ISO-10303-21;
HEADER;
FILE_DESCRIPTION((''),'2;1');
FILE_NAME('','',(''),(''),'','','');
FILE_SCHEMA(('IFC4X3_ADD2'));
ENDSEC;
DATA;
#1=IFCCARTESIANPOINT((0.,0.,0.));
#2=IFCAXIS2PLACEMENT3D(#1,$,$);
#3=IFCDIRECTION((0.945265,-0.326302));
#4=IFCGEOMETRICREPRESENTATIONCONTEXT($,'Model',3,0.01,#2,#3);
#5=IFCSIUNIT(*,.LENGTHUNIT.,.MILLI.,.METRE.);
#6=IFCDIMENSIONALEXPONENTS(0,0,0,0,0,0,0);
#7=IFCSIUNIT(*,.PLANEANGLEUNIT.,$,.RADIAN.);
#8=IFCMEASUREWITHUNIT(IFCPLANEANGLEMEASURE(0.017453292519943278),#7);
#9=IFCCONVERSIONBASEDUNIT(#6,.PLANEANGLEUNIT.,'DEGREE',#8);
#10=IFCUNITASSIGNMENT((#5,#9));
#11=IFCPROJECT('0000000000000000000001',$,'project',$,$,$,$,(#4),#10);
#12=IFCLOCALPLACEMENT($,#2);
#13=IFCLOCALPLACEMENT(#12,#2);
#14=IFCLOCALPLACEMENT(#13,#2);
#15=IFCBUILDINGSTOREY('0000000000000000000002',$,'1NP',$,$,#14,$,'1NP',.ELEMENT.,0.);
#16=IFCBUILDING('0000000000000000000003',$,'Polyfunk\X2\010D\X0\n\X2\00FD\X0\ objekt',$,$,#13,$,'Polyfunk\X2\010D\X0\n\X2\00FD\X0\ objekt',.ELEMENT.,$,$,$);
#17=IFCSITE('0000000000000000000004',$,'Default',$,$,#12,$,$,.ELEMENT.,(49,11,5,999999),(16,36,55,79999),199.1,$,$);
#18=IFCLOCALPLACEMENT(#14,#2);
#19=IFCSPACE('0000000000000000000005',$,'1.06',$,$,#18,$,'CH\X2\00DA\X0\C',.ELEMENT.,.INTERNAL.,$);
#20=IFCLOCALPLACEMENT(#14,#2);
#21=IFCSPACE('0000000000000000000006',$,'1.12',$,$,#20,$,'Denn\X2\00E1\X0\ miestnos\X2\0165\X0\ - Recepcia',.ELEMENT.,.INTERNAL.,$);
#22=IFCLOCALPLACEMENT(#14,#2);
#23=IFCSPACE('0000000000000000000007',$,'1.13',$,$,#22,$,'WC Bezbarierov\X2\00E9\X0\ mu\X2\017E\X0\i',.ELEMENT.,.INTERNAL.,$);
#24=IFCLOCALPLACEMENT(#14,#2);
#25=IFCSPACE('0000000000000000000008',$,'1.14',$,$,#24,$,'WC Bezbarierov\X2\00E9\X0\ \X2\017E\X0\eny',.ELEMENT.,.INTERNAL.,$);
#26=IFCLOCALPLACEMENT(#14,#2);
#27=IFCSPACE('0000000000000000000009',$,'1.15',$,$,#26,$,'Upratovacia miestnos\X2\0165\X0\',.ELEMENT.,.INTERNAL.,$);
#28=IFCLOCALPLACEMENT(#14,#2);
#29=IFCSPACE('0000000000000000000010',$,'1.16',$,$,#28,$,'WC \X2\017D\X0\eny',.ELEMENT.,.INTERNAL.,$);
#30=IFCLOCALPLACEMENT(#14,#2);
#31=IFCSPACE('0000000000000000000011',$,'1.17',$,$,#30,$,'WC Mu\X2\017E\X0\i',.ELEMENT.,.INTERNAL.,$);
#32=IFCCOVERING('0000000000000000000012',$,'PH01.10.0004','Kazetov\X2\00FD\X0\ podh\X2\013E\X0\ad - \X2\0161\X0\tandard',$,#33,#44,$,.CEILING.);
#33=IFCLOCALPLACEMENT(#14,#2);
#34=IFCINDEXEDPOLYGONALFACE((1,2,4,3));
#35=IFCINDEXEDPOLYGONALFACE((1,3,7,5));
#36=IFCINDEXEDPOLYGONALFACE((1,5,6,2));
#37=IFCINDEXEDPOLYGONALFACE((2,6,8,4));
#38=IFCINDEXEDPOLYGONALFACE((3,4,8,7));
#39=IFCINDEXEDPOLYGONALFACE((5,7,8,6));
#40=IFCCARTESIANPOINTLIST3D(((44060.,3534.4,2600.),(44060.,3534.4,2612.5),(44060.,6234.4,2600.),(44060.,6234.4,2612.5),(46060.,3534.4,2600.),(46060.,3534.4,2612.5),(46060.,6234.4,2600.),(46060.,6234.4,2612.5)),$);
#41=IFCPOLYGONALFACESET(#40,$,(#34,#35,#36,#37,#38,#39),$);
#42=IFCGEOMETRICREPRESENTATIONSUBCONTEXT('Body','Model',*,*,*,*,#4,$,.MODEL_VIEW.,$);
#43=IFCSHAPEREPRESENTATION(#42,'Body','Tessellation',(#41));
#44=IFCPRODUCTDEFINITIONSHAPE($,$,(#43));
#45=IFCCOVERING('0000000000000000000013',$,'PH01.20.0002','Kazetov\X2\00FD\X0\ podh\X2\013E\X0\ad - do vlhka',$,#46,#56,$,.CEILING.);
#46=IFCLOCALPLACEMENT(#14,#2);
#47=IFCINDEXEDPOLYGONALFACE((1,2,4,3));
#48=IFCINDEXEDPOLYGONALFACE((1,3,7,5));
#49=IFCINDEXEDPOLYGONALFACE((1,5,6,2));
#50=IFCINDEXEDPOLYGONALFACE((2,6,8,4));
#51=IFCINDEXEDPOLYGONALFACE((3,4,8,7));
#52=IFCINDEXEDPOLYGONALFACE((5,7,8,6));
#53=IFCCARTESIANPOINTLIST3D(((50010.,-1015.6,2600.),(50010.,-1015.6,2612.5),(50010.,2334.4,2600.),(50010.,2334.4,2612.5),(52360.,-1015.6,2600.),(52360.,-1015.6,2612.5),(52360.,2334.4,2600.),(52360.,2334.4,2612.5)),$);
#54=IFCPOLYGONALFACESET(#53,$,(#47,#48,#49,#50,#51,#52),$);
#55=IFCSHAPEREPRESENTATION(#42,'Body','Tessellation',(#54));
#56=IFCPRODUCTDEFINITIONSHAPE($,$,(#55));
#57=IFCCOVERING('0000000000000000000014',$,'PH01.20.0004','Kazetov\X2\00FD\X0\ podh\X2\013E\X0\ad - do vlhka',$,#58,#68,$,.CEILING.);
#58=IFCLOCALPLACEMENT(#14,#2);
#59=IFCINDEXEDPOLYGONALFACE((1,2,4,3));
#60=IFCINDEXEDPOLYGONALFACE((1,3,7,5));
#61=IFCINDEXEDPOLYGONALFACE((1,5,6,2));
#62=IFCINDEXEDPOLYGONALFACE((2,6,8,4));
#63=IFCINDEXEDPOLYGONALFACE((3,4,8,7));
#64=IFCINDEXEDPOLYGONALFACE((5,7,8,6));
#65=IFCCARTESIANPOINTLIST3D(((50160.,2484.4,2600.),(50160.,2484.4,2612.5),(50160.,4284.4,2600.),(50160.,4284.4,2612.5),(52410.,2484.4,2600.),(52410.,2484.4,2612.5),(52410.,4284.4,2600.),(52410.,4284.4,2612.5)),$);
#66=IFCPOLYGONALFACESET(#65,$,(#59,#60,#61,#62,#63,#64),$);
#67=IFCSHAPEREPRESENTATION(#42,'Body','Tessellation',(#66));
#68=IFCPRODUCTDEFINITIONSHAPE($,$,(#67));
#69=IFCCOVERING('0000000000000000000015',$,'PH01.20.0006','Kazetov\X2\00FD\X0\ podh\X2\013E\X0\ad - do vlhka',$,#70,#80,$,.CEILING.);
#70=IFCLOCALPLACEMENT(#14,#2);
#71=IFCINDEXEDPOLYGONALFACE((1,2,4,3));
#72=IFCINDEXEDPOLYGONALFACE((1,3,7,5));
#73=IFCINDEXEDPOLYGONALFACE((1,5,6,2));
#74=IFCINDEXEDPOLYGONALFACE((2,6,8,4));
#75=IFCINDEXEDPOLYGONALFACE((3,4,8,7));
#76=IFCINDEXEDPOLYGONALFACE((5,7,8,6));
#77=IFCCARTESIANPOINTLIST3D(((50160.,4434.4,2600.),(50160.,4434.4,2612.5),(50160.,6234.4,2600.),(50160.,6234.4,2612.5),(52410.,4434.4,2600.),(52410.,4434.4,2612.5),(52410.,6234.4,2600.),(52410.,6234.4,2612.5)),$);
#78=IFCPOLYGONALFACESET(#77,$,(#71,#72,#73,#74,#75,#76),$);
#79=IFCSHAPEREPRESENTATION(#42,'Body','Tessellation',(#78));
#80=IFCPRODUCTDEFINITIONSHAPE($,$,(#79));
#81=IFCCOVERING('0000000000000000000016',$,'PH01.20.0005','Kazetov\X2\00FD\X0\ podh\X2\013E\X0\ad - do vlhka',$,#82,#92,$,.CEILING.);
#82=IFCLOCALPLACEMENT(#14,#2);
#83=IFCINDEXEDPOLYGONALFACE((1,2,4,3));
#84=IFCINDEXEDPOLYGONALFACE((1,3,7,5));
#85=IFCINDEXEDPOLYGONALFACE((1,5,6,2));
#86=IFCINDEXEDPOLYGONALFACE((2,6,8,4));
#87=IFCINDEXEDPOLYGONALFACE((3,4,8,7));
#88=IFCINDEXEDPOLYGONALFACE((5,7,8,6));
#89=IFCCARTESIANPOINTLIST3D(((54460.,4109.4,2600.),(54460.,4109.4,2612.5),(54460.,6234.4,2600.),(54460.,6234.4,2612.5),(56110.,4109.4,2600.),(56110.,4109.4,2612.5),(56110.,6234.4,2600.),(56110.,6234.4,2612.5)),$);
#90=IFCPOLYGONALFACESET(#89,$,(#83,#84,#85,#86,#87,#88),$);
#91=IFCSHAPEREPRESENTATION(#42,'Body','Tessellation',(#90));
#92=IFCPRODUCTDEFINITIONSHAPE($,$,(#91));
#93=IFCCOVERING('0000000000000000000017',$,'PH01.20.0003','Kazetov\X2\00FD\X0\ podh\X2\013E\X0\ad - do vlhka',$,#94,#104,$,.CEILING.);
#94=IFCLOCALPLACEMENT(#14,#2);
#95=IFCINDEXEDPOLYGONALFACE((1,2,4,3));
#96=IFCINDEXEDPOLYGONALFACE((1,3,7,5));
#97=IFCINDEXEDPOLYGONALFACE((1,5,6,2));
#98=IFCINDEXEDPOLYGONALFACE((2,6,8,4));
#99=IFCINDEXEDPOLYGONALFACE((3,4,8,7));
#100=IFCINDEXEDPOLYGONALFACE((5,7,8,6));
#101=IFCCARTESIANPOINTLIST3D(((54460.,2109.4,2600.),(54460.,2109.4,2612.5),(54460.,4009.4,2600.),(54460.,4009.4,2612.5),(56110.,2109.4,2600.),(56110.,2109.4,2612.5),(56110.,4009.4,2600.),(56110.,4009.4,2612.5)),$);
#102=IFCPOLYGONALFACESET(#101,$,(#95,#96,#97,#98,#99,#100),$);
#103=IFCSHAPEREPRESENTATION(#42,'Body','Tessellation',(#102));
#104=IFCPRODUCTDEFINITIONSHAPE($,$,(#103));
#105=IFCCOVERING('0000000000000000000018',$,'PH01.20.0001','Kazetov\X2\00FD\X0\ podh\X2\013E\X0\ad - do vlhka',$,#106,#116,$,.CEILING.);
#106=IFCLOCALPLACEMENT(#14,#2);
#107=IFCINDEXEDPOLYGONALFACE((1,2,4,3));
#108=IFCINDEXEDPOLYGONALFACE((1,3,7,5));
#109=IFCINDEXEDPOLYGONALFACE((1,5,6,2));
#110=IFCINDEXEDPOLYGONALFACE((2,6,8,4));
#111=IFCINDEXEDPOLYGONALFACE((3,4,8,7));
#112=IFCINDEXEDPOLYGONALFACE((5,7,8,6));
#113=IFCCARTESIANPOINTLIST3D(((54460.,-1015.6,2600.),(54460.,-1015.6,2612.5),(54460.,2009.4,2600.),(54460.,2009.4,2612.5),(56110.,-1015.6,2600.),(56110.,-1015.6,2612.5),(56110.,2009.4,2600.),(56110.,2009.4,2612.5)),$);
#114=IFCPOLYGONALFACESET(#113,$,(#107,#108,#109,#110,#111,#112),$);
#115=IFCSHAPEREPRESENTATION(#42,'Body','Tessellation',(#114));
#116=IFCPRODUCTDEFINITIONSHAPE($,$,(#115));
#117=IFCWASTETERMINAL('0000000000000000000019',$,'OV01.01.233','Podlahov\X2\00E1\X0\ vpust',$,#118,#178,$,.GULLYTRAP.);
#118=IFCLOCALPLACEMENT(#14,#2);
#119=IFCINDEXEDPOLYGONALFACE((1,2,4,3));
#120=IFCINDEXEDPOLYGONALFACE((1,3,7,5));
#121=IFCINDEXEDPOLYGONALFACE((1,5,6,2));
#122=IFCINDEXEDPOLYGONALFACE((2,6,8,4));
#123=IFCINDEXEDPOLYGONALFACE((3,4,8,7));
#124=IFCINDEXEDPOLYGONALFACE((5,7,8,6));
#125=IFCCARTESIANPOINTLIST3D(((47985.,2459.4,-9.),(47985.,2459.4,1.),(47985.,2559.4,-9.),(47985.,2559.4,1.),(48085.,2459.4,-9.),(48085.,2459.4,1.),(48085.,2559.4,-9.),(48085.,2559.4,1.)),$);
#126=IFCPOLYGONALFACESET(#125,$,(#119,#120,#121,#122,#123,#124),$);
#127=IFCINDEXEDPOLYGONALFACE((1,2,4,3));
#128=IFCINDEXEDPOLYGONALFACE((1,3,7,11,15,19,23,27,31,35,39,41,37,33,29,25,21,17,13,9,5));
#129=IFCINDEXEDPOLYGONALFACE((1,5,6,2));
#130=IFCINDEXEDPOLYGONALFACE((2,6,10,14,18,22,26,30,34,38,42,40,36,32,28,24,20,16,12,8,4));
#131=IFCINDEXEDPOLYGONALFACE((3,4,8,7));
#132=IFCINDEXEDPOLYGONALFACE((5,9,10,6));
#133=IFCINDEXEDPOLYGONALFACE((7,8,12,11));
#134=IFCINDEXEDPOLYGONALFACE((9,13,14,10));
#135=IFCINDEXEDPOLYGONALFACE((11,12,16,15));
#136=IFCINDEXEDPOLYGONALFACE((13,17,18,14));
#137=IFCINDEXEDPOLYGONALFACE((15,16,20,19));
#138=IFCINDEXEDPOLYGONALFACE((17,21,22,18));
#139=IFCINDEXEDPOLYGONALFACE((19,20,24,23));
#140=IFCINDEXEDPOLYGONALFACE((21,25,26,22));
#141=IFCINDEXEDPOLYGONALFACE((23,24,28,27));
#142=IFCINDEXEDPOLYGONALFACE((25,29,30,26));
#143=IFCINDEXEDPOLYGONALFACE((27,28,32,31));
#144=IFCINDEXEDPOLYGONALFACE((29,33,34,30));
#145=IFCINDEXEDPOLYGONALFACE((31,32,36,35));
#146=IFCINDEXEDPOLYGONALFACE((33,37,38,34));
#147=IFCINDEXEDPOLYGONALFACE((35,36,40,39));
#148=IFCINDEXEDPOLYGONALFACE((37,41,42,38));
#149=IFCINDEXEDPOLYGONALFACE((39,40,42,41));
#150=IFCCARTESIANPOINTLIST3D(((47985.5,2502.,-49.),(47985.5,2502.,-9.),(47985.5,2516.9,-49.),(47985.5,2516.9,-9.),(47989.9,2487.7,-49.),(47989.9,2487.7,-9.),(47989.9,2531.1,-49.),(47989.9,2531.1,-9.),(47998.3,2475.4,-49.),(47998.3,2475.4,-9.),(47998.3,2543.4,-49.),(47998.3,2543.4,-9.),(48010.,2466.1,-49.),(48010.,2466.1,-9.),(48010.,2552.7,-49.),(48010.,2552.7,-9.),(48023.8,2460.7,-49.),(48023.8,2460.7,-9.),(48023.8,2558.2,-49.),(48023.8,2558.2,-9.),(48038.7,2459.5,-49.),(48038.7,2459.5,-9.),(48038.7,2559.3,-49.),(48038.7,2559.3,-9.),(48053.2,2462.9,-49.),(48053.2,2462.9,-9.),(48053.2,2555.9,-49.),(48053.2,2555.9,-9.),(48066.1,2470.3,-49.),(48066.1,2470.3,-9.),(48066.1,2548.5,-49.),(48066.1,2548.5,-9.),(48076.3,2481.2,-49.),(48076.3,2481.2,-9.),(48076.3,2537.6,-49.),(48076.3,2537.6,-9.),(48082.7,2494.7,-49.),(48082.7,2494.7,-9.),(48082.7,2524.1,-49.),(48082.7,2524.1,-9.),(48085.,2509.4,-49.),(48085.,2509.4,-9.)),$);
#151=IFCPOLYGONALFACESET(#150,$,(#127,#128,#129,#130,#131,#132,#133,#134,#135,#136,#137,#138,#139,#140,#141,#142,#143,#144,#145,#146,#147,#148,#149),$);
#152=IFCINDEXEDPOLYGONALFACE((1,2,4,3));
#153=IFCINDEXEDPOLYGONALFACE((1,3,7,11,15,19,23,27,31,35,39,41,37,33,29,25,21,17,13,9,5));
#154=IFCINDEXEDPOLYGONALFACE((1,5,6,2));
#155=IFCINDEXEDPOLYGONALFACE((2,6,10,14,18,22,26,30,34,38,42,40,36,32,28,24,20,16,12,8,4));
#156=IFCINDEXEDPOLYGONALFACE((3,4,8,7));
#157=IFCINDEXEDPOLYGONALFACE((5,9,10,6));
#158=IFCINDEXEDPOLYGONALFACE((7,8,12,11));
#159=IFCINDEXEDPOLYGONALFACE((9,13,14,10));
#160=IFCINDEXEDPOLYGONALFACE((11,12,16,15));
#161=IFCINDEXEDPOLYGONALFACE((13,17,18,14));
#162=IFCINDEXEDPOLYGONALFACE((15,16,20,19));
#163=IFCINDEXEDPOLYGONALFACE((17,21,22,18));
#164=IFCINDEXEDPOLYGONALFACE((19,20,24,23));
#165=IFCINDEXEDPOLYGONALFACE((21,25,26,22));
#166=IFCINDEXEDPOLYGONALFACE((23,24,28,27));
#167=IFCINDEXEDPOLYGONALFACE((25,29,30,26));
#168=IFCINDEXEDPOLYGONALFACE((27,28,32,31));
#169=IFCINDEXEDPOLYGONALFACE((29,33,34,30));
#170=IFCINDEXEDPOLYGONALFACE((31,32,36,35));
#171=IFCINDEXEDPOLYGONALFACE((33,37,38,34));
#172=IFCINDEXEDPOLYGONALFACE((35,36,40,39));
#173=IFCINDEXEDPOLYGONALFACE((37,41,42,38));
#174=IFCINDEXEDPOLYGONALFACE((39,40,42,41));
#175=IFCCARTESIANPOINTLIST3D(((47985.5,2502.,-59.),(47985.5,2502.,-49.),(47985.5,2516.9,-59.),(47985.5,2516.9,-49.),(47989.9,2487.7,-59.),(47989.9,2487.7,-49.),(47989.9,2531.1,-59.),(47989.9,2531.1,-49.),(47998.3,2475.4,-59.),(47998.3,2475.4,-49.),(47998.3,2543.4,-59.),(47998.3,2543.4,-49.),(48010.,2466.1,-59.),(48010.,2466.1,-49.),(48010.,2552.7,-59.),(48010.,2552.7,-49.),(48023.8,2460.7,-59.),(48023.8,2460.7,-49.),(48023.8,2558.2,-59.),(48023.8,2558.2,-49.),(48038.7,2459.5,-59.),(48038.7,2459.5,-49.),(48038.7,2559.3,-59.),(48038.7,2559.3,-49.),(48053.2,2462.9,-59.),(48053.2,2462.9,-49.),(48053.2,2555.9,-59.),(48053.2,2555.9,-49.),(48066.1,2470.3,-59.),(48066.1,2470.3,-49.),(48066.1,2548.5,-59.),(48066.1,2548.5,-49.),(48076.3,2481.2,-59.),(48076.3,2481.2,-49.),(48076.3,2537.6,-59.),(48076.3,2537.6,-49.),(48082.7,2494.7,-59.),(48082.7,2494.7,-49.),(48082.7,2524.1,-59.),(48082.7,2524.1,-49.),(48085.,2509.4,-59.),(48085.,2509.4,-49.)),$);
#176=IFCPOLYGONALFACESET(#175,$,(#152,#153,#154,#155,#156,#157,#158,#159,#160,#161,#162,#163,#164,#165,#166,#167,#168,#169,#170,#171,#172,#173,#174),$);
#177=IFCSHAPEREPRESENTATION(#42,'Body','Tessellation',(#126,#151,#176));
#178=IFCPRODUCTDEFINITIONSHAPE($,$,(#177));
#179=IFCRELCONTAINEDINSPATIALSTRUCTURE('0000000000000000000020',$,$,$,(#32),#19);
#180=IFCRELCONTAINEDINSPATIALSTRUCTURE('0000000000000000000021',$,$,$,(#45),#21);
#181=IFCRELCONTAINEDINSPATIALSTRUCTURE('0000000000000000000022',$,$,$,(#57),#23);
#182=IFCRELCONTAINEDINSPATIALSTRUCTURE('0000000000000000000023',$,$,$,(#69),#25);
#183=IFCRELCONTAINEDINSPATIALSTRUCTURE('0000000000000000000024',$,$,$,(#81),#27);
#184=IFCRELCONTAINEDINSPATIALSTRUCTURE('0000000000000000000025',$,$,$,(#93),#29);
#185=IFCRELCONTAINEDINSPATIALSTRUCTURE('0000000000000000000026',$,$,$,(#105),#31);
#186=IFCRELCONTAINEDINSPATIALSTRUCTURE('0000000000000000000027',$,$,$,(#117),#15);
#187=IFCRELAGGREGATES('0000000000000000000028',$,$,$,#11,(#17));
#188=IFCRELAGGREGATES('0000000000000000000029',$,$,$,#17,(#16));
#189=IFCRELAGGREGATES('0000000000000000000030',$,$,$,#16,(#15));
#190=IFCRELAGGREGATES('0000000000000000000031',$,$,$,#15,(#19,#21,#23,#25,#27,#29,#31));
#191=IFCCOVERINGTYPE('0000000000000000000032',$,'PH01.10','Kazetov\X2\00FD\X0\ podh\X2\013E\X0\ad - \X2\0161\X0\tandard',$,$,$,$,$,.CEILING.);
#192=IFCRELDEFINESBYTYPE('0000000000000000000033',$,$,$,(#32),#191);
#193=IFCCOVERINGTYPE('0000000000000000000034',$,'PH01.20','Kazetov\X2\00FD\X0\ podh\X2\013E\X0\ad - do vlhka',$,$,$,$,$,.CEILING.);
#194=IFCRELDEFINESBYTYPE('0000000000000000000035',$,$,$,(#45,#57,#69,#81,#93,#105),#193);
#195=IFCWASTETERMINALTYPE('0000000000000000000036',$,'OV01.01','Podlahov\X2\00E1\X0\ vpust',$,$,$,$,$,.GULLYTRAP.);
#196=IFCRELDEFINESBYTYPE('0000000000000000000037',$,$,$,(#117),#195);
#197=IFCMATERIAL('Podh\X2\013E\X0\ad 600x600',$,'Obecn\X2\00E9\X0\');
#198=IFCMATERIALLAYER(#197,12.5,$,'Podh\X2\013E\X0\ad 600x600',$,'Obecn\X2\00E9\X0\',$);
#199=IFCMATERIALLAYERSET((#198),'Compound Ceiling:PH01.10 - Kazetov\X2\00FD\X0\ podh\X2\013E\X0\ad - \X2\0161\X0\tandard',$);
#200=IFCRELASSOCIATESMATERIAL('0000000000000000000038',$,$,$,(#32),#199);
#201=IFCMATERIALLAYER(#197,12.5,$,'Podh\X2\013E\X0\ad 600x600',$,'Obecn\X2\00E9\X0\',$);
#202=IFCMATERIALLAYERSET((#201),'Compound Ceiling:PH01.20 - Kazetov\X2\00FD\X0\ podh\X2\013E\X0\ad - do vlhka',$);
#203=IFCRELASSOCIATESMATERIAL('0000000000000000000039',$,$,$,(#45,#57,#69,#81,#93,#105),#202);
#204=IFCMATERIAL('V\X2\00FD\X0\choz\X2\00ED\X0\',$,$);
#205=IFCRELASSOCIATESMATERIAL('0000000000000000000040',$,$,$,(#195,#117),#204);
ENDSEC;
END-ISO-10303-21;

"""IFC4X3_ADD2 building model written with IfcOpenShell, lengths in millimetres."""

from ifc_helpers import new_model, entity, si_unit, converted_unit, direction, frame, frame_2d, origin, place, context, subcontext, project, spatial, rectangle, circle, extrude, source, transform, mapped, material, layer, layer_set, layer_usage, type_object, type_shapes, element, save


model = new_model("IFC4X3_ADD2")

# Units and contexts
model_context = context("Model", 3, precision=0.01, world=origin(), true_north=direction((0.945265, -0.326302)))
body_context = subcontext(model_context, "Body", "Model", "MODEL_VIEW")
ifc_project = project(units=[si_unit("LENGTHUNIT", "METRE", prefix="MILLI"), converted_unit("PLANEANGLEUNIT", "DEGREE", entity("IfcPlaneAngleMeasure", 0.017453292519943278), si_unit("PLANEANGLEUNIT", "RADIAN"), dimensions=[0, 0, 0, 0, 0, 0, 0])], contexts=[model_context])

# Site, building, storey
site_placement = place(None, origin())
site = spatial("IfcSite", under=ifc_project, at=site_placement, Name="Default", CompositionType="ELEMENT", RefLatitude=(49, 11, 5, 999999), RefLongitude=(16, 36, 55, 79999), RefElevation=199.1)
building_placement = place(site_placement, origin())
building = spatial("IfcBuilding", under=site, at=building_placement, Name="Polyfunkčný objekt", LongName="Polyfunkčný objekt", CompositionType="ELEMENT")
storey_placement = place(building_placement, origin())
storey = spatial("IfcBuildingStorey", under=building, at=storey_placement, Name="1NP", LongName="1NP", CompositionType="ELEMENT", Elevation=0.0)

# Shared definitions
ifc_material_1 = material(Name="Podhľad 600x600", Category="Obecné")
ifc_layer_1 = layer(ifc_material_1, 12.5, Name="Podhľad 600x600", Category="Obecné")
ifc_layer_set_1 = layer_set([ifc_layer_1], Name="Compound Ceiling:PH01.10 - Kazetový podhľad - štandard")
covering_type_1 = type_object("IfcCoveringType", Name="PH01.10", Description="Kazetový podhľad - štandard", PredefinedType="CEILING")

# Shared definitions
space_1_placement = place(storey_placement, origin())
space_1 = spatial("IfcSpace", under=storey, at=space_1_placement, Name="1.06", LongName="CHÚC", CompositionType="ELEMENT", PredefinedType="INTERNAL")

# Covering
ifc_layer_usage_1 = layer_usage(ifc_layer_set_1, "AXIS3", "NEGATIVE", 0.0)
covering_1_placement = place(storey_placement, frame((44060.0, 3534.4, 2600.0)))
element("IfcCovering", 1, at=covering_1_placement, inside=space_1, type_object=covering_type_1, material=ifc_layer_usage_1, Name="PH01.10.0004", Description="Kazetový podhľad - štandard", PredefinedType="CEILING", context=body_context, shape_type="SweptSolid", body=[
    extrude(rectangle(XDim=2000.0, YDim=2700.0, at=frame_2d((0.0, 0.0), x_axis=(1.0, 0.0))), frame((1000.0, 1350.0, 0.0)), (0.0, 0.0, 1.0), 12.5),
])

# Shared definitions
space_2_placement = place(storey_placement, origin())
space_2 = spatial("IfcSpace", under=storey, at=space_2_placement, Name="1.12", LongName="Denná miestnosť - Recepcia", CompositionType="ELEMENT", PredefinedType="INTERNAL")

# Covering
ifc_layer_2 = layer(ifc_material_1, 12.5, Name="Podhľad 600x600", Category="Obecné")
ifc_layer_set_2 = layer_set([ifc_layer_2], Name="Compound Ceiling:PH01.20 - Kazetový podhľad - do vlhka")
ifc_layer_usage_2 = layer_usage(ifc_layer_set_2, "AXIS3", "NEGATIVE", 12.5)
covering_type_2 = type_object("IfcCoveringType", Name="PH01.20", Description="Kazetový podhľad - do vlhka", PredefinedType="CEILING")
covering_2_placement = place(storey_placement, frame((50010.0, -1015.6, 2600.0)))
element("IfcCovering", 2, at=covering_2_placement, inside=space_2, type_object=covering_type_2, material=ifc_layer_usage_2, Name="PH01.20.0002", Description="Kazetový podhľad - do vlhka", PredefinedType="CEILING", context=body_context, shape_type="SweptSolid", body=[
    extrude(rectangle(XDim=3350.0, YDim=2350.0, at=frame_2d((0.0, 0.0), x_axis=(1.0, 0.0))), frame((1175.0, 1675.0, 0.0), z_axis=(0.0, 0.0, 1.0), x_axis=(0.0, 1.0, 0.0)), (0.0, 0.0, 1.0), 12.5),
])

# Shared definitions
space_3_placement = place(storey_placement, origin())
space_3 = spatial("IfcSpace", under=storey, at=space_3_placement, Name="1.13", LongName="WC Bezbarierové muži", CompositionType="ELEMENT", PredefinedType="INTERNAL")

# Covering
ifc_layer_usage_3 = layer_usage(ifc_layer_set_2, "AXIS3", "NEGATIVE", 0.0)
covering_3_placement = place(storey_placement, frame((50160.0, 2484.4, 2600.0)))
element("IfcCovering", 3, at=covering_3_placement, inside=space_3, type_object=covering_type_2, material=ifc_layer_usage_3, Name="PH01.20.0004", Description="Kazetový podhľad - do vlhka", PredefinedType="CEILING", context=body_context, shape_type="SweptSolid", body=[
    extrude(rectangle(XDim=2250.0, YDim=1800.0, at=frame_2d((0.0, 0.0), x_axis=(1.0, 0.0))), frame((1125.0, 900.0, 0.0), z_axis=(0.0, 0.0, 1.0), x_axis=(-1.0, 0.0, 0.0)), (0.0, 0.0, 1.0), 12.5),
])

# Shared definitions
space_4_placement = place(storey_placement, origin())
space_4 = spatial("IfcSpace", under=storey, at=space_4_placement, Name="1.14", LongName="WC Bezbarierové ženy", CompositionType="ELEMENT", PredefinedType="INTERNAL")

# Covering
ifc_layer_usage_4 = layer_usage(ifc_layer_set_2, "AXIS3", "NEGATIVE", 0.0)
covering_4_placement = place(storey_placement, frame((50160.0, 4434.4, 2600.0)))
element("IfcCovering", 4, at=covering_4_placement, inside=space_4, type_object=covering_type_2, material=ifc_layer_usage_4, Name="PH01.20.0006", Description="Kazetový podhľad - do vlhka", PredefinedType="CEILING", context=body_context, shape_type="SweptSolid", body=[
    extrude(rectangle(XDim=1800.0, YDim=2250.0, at=frame_2d((0.0, 0.0), x_axis=(1.0, 0.0))), frame((1125.0, 900.0, 0.0), z_axis=(0.0, 0.0, 1.0), x_axis=(0.0, -1.0, 0.0)), (0.0, 0.0, 1.0), 12.5),
])

# Shared definitions
space_5_placement = place(storey_placement, origin())
space_5 = spatial("IfcSpace", under=storey, at=space_5_placement, Name="1.15", LongName="Upratovacia miestnosť", CompositionType="ELEMENT", PredefinedType="INTERNAL")

# Covering
ifc_layer_usage_5 = layer_usage(ifc_layer_set_2, "AXIS3", "NEGATIVE", 0.0)
covering_5_placement = place(storey_placement, frame((54460.0, 4109.4, 2600.0)))
element("IfcCovering", 5, at=covering_5_placement, inside=space_5, type_object=covering_type_2, material=ifc_layer_usage_5, Name="PH01.20.0005", Description="Kazetový podhľad - do vlhka", PredefinedType="CEILING", context=body_context, shape_type="SweptSolid", body=[
    extrude(rectangle(XDim=2125.0, YDim=1650.0, at=frame_2d((0.0, 0.0), x_axis=(1.0, 0.0))), frame((825.0, 1062.5, 0.0), z_axis=(0.0, 0.0, 1.0), x_axis=(0.0, -1.0, 0.0)), (0.0, 0.0, 1.0), 12.5),
])

# Shared definitions
space_6_placement = place(storey_placement, origin())
space_6 = spatial("IfcSpace", under=storey, at=space_6_placement, Name="1.16", LongName="WC Ženy", CompositionType="ELEMENT", PredefinedType="INTERNAL")

# Covering
ifc_layer_usage_6 = layer_usage(ifc_layer_set_2, "AXIS3", "NEGATIVE", 0.0)
covering_6_placement = place(storey_placement, frame((54460.0, 2109.4, 2600.0)))
element("IfcCovering", 6, at=covering_6_placement, inside=space_6, type_object=covering_type_2, material=ifc_layer_usage_6, Name="PH01.20.0003", Description="Kazetový podhľad - do vlhka", PredefinedType="CEILING", context=body_context, shape_type="SweptSolid", body=[
    extrude(rectangle(XDim=1900.0, YDim=1650.0, at=frame_2d((0.0, 0.0), x_axis=(1.0, 0.0))), frame((825.0, 950.0, 0.0), z_axis=(0.0, 0.0, 1.0), x_axis=(0.0, 1.0, 0.0)), (0.0, 0.0, 1.0), 12.5),
])

# Shared definitions
space_7_placement = place(storey_placement, origin())
space_7 = spatial("IfcSpace", under=storey, at=space_7_placement, Name="1.17", LongName="WC Muži", CompositionType="ELEMENT", PredefinedType="INTERNAL")

# Covering
ifc_layer_usage_7 = layer_usage(ifc_layer_set_2, "AXIS3", "NEGATIVE", 0.0)
covering_7_placement = place(storey_placement, frame((54460.0, -1015.6, 2600.0)))
element("IfcCovering", 7, at=covering_7_placement, inside=space_7, type_object=covering_type_2, material=ifc_layer_usage_7, Name="PH01.20.0001", Description="Kazetový podhľad - do vlhka", PredefinedType="CEILING", context=body_context, shape_type="SweptSolid", body=[
    extrude(rectangle(XDim=1650.0, YDim=3025.0, at=frame_2d((0.0, 0.0), x_axis=(1.0, 0.0))), frame((825.0, 1512.5, 0.0), z_axis=(0.0, 0.0, 1.0), x_axis=(-1.0, 0.0, 0.0)), (0.0, 0.0, 1.0), 12.5),
])

# Waste terminal
ifc_material_2 = material(Name="Výchozí")
waste_terminal_type = type_object("IfcWasteTerminalType", Name="OV01.01", Description="Podlahová vpust", PredefinedType="GULLYTRAP", material=ifc_material_2)
shared_shape_1 = source(origin(), body_context, "Body", "SweptSolid", [
    extrude(rectangle(XDim=100.0, YDim=100.0, at=frame_2d((0.0, 0.0), x_axis=(1.0, 0.0))), frame((0.0, 0.0, -10.0), z_axis=(0.0, 0.0, 1.0), x_axis=(-1.0, 0.0, 0.0)), (0.0, 0.0, 1.0), 10.0),
    extrude(circle(Radius=50.0, at=frame_2d((0.0, 0.0), x_axis=(1.0, 0.0))), frame((0.0, 0.0, -50.0)), (0.0, 0.0, 1.0), 40.0),
    extrude(circle(Radius=50.0, at=frame_2d((0.0, 0.0), x_axis=(1.0, 0.0))), frame((0.0, 0.0, -60.0)), (0.0, 0.0, 1.0), 10.0),
])
type_shapes(waste_terminal_type, [shared_shape_1])
waste_terminal_1_placement = place(storey_placement, frame((48035.0, 2509.4, 1.0)))
element("IfcWasteTerminal", 8, at=waste_terminal_1_placement, inside=storey, type_object=waste_terminal_type, material=ifc_material_2, Name="OV01.01.233", Description="Podlahová vpust", PredefinedType="GULLYTRAP", context=body_context, shape_type="MappedRepresentation", body=[
    mapped(shared_shape_1, transform((0.0, 0.0, 0.0), scale=1.0)),
])

save(model, "model.ifc")
